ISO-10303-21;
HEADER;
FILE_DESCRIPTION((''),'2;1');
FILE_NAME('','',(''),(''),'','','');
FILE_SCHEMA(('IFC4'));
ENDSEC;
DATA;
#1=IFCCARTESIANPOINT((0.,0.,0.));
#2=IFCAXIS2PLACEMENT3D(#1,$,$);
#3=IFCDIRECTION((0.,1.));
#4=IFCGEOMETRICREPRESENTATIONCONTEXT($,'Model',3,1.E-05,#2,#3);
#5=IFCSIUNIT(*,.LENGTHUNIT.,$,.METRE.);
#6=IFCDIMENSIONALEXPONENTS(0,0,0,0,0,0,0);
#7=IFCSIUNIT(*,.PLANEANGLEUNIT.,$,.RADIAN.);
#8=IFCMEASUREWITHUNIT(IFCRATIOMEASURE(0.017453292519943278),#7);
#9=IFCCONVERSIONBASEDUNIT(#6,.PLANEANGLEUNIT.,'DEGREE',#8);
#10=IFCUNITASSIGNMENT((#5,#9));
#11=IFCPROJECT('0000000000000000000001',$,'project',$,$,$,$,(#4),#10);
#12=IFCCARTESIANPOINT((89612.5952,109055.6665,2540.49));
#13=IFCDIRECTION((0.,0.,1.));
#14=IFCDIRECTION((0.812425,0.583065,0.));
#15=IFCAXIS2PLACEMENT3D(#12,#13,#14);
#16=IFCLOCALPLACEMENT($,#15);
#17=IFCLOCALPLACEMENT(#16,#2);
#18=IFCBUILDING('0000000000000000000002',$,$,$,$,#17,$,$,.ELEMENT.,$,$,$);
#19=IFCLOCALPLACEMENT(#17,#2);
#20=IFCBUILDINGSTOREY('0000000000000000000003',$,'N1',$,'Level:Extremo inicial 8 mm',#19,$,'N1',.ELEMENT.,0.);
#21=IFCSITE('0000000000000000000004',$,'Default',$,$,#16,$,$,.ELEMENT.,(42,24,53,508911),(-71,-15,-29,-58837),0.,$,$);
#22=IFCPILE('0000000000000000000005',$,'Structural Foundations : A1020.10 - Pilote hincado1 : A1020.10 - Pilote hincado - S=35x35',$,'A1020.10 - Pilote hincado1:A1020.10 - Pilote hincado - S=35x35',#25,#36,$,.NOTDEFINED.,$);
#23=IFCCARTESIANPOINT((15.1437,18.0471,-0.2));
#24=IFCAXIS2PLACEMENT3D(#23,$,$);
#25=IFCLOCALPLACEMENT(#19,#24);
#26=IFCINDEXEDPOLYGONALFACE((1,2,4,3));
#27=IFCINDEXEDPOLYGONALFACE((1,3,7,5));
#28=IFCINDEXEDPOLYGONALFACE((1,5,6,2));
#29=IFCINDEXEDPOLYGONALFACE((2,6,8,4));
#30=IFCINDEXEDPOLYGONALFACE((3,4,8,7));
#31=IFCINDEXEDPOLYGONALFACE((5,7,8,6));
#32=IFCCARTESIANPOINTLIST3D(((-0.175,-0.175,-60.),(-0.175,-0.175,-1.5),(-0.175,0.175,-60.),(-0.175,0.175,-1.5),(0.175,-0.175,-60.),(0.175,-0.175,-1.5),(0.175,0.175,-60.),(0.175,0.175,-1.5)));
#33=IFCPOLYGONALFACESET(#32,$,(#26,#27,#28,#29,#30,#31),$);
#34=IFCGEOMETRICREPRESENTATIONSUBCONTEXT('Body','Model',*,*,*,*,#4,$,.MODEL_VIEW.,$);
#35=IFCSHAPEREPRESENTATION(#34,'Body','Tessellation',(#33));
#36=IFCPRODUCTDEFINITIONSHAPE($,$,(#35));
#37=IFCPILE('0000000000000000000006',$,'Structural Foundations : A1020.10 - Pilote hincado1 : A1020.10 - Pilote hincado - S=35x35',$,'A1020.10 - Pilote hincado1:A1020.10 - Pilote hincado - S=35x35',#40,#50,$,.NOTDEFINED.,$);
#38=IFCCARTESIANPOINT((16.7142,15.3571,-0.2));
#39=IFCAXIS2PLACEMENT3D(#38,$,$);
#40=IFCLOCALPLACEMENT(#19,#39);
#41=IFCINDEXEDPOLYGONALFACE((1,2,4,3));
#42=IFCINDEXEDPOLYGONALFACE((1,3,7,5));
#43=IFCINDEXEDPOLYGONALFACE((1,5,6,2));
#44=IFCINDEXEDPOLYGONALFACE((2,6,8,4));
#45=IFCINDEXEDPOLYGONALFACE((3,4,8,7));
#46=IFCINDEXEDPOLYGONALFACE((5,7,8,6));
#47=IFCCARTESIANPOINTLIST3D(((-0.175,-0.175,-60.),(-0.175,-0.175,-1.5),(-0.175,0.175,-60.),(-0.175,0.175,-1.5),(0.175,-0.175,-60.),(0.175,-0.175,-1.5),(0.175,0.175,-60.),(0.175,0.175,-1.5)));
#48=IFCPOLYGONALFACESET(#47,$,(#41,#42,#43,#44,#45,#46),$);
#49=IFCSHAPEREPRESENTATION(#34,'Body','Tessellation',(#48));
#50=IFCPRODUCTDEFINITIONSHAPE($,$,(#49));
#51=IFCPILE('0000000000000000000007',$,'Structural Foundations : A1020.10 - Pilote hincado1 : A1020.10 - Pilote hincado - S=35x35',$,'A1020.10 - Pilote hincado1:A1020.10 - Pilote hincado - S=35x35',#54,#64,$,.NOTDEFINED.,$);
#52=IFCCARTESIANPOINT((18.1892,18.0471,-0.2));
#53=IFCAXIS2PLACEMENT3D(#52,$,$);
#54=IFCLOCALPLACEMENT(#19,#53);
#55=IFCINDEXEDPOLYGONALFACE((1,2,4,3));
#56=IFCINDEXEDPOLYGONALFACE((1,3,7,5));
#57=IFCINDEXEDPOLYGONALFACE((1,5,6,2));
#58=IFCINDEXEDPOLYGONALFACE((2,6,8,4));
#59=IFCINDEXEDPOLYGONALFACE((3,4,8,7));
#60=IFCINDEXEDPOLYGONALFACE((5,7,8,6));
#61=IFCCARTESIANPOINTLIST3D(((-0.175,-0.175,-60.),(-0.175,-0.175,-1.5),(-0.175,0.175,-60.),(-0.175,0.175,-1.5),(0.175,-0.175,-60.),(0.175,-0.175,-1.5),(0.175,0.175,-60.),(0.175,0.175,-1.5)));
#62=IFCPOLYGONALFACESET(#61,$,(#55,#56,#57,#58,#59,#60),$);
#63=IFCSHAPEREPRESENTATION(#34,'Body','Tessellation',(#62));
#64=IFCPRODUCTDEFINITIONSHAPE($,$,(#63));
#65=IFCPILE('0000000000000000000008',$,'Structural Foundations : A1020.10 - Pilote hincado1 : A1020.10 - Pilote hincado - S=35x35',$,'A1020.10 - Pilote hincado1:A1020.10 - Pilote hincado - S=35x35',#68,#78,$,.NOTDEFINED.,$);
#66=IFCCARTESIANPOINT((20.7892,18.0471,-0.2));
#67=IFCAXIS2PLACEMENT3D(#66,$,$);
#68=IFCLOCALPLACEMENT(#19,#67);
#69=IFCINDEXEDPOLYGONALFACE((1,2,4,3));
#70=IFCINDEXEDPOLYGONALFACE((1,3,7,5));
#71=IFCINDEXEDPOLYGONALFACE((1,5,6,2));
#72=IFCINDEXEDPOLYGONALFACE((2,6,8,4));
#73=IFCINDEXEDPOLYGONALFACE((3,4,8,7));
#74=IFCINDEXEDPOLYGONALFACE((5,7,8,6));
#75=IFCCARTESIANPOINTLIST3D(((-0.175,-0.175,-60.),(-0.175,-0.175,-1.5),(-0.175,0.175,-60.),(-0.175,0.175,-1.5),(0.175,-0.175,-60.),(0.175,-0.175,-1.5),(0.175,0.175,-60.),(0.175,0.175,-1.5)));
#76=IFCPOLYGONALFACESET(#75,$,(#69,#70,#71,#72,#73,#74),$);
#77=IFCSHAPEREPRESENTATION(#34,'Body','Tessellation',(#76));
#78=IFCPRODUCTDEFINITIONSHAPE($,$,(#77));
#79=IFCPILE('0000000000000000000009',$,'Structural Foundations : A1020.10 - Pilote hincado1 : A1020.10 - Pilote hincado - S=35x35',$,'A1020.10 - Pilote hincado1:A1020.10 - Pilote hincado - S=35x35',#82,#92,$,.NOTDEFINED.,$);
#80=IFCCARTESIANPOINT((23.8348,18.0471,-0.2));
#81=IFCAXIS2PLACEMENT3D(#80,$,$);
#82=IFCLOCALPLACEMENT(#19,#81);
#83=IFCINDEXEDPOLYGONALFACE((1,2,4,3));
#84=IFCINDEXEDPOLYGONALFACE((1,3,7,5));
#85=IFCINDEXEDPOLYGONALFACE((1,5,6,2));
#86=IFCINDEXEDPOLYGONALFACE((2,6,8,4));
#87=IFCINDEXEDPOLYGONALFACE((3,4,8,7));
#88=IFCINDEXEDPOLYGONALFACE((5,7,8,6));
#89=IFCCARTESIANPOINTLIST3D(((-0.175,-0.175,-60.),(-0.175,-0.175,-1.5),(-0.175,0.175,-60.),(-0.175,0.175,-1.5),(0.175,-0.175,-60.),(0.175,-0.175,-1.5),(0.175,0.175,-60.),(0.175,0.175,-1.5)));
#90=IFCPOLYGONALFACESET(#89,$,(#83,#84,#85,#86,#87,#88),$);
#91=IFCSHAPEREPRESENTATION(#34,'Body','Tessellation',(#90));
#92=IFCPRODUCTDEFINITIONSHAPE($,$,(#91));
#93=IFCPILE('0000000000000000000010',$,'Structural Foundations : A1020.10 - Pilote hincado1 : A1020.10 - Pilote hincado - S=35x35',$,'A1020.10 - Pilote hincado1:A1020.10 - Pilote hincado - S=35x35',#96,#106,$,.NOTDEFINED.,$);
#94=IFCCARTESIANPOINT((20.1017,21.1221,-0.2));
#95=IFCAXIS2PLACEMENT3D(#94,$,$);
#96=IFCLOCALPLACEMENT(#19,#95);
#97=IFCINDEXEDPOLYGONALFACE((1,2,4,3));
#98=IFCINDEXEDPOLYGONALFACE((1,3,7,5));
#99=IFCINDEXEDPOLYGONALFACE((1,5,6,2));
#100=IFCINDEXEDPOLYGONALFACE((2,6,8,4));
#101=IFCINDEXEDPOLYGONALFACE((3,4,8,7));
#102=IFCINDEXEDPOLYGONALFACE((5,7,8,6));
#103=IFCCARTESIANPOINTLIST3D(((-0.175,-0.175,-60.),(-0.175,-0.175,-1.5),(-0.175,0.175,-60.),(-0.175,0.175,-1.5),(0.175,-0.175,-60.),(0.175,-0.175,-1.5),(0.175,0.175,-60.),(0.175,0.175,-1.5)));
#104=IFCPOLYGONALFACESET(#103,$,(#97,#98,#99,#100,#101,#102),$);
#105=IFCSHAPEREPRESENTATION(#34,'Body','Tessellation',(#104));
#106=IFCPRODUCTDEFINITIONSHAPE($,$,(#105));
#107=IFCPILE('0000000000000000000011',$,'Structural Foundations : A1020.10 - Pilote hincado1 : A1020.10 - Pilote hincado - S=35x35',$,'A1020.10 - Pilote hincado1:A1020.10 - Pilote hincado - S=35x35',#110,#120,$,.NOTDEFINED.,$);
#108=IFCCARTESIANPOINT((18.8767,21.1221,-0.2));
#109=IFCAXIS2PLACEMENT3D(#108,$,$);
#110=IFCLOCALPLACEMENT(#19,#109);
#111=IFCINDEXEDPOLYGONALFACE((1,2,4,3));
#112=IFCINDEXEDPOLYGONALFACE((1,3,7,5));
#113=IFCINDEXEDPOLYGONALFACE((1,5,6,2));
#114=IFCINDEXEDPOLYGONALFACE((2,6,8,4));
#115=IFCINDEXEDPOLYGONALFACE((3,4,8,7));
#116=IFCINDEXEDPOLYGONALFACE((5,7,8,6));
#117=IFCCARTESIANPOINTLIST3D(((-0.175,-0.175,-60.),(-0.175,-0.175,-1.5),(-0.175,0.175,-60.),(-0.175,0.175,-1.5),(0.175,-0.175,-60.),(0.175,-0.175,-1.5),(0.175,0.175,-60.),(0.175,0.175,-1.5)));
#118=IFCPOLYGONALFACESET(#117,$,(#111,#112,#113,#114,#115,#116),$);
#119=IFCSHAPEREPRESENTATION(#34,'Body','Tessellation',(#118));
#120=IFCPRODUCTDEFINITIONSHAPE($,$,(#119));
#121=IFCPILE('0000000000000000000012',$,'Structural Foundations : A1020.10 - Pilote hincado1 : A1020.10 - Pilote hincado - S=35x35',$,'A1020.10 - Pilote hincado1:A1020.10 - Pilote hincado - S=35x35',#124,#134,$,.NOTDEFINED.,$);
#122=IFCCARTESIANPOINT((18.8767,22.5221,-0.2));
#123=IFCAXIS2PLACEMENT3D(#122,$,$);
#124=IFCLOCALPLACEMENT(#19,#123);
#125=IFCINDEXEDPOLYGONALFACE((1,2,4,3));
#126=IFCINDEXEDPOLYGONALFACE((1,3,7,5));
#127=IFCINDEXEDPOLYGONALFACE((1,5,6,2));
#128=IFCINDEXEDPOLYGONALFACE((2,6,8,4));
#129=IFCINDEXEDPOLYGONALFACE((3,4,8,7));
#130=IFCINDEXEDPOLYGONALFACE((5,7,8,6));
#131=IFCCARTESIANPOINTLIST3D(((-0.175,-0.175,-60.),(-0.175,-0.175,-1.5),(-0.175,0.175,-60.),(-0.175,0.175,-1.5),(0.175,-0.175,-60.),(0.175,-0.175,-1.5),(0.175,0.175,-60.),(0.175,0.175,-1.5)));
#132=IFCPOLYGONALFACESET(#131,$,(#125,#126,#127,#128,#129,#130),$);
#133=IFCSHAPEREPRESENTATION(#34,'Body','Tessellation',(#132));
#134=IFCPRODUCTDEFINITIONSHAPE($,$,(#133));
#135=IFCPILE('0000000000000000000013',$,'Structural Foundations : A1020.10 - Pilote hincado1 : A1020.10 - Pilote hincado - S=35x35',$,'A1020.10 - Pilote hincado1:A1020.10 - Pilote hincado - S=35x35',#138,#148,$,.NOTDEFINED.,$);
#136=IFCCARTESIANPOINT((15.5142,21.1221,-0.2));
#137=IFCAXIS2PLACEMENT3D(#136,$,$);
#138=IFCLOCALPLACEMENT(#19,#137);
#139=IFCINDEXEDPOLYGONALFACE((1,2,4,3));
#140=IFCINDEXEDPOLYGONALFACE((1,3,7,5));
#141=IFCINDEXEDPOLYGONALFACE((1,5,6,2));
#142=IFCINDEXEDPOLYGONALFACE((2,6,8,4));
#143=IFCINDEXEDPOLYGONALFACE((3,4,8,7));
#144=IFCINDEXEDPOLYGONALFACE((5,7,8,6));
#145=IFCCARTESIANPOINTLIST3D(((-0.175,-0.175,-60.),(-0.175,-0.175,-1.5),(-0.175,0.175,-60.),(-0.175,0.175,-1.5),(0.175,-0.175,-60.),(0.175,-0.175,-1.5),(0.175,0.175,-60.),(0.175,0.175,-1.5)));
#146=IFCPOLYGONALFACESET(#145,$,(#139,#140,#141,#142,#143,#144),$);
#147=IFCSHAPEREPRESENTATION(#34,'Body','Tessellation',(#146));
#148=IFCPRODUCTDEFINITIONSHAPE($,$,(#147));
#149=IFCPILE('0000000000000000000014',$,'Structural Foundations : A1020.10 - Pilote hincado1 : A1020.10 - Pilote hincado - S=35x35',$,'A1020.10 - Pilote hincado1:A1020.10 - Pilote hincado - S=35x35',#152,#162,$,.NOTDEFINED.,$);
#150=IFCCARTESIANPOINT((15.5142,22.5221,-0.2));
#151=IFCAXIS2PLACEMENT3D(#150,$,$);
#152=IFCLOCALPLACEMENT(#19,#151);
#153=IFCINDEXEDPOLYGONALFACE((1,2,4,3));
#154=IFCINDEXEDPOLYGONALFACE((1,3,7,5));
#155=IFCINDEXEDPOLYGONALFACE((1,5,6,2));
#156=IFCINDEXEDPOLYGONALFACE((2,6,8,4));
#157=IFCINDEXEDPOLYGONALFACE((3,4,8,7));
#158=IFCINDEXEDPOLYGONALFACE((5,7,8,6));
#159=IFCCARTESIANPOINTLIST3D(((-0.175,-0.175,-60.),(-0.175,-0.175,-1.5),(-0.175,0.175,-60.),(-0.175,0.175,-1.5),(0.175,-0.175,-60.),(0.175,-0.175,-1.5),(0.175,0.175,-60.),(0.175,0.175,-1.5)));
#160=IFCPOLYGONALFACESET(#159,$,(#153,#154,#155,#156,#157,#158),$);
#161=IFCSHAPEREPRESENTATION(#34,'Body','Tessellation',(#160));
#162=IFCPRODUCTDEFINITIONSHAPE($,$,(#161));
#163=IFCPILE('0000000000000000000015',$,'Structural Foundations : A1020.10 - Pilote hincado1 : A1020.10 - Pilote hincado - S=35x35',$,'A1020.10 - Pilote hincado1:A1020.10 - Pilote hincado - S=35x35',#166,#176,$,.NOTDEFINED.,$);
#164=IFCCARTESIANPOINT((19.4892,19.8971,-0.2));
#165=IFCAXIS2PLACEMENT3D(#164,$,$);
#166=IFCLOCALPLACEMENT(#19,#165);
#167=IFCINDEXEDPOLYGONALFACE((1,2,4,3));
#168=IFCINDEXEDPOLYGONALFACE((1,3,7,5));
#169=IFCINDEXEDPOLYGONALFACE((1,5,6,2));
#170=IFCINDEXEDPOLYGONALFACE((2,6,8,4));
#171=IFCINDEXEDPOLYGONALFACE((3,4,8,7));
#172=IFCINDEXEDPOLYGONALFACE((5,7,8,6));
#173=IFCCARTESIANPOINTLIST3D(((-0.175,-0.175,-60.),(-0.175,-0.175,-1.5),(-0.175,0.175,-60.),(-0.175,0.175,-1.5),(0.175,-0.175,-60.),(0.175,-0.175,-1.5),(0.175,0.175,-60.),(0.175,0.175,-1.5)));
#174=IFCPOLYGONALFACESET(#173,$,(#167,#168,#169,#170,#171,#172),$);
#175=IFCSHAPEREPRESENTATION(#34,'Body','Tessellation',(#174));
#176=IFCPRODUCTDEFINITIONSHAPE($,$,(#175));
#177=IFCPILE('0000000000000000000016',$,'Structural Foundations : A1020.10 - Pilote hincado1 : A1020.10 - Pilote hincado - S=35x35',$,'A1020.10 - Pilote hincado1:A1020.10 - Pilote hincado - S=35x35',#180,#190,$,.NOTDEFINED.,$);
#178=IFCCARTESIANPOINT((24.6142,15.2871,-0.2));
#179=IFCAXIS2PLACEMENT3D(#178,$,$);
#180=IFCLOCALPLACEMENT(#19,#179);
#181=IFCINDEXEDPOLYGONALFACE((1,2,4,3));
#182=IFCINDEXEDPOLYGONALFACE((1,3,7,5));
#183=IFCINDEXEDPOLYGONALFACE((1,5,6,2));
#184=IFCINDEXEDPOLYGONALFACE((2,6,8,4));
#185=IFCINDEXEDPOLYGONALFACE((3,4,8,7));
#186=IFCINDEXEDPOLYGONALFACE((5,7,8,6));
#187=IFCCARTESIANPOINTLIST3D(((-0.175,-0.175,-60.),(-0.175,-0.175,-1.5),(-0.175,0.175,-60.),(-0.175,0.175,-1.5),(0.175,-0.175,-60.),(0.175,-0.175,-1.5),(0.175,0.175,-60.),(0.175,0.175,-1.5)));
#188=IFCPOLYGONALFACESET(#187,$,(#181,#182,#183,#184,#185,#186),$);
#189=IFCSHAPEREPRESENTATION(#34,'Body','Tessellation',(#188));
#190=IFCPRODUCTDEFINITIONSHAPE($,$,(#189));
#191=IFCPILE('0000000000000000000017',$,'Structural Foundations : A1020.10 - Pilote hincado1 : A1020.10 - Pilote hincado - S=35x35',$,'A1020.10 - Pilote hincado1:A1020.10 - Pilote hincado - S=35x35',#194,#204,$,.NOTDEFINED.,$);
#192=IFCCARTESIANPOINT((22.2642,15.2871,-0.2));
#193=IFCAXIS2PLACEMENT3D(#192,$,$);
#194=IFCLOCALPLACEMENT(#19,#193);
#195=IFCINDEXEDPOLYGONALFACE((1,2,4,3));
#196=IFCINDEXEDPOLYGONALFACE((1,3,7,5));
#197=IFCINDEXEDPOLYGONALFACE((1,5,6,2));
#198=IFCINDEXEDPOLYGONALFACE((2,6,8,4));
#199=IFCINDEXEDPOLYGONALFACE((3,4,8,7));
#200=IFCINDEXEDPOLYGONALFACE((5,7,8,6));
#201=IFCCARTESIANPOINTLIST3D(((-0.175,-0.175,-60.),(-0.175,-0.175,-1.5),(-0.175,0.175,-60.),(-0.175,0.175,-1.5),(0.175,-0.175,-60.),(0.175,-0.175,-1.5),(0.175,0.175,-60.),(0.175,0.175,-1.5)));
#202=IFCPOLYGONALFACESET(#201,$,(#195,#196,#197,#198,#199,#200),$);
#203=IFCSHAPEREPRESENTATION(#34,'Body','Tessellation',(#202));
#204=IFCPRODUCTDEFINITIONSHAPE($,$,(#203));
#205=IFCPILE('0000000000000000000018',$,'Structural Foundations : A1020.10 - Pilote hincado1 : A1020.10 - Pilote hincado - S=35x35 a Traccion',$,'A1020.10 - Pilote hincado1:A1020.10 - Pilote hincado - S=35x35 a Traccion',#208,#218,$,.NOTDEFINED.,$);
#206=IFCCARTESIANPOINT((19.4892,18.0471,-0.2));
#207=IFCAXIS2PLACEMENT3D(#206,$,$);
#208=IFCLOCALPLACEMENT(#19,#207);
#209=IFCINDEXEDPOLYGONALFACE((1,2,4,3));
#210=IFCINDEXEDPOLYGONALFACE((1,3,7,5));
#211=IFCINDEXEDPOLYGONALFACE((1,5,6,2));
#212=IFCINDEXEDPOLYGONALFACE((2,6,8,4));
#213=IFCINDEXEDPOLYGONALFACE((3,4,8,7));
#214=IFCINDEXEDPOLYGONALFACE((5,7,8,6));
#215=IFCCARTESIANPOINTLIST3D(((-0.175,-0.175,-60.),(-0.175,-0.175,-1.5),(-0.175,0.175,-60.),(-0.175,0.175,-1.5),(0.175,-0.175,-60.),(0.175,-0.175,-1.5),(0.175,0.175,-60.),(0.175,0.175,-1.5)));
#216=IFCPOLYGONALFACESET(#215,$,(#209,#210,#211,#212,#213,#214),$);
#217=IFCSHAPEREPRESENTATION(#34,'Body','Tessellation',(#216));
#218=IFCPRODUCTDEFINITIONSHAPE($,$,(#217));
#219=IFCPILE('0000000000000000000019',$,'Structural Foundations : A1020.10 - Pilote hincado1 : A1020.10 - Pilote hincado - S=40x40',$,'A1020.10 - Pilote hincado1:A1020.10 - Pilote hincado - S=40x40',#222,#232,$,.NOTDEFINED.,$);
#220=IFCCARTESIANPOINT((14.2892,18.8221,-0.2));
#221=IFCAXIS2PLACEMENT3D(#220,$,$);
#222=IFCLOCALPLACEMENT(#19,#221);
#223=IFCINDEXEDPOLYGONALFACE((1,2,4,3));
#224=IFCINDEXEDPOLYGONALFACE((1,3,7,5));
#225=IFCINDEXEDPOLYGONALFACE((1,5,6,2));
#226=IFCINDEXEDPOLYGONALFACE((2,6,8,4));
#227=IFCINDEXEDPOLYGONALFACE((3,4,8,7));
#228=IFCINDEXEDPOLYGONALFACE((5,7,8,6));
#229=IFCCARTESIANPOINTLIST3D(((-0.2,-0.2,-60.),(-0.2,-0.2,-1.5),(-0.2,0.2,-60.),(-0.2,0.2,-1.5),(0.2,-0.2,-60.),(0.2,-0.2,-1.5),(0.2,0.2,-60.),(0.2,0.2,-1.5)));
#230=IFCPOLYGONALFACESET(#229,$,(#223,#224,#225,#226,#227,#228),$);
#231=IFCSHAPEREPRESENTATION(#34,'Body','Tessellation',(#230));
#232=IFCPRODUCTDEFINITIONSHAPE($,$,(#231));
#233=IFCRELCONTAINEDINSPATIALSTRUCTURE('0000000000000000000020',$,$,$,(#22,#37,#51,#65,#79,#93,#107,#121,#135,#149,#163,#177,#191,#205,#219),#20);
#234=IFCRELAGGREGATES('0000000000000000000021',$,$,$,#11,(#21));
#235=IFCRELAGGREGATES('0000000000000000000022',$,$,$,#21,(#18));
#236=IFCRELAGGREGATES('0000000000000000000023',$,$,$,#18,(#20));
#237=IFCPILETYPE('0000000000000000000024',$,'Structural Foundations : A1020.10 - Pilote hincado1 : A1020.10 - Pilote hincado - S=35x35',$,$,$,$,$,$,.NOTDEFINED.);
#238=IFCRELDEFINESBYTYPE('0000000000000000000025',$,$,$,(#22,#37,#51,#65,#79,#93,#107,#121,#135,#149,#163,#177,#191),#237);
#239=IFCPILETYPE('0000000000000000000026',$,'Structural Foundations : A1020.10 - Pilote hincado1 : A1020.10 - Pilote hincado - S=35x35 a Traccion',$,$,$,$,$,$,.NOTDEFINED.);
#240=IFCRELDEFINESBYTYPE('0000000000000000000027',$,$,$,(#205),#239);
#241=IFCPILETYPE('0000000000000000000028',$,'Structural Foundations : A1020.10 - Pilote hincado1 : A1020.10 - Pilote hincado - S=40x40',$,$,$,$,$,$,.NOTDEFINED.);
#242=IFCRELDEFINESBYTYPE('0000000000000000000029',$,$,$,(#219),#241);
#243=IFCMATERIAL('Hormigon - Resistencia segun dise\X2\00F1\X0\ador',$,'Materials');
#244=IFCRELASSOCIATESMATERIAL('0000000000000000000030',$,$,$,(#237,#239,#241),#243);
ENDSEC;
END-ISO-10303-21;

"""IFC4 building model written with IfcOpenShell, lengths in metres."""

from ifc_helpers import new_model, entity, si_unit, converted_unit, direction, frame, origin, origin_2d_with_axis, place, context, subcontext, project, spatial, polyline, segment, composite_curve, rectangle, outline, extrude, source, transform, mapped, material, material_profile, profile_set, type_object, type_shapes, element, save


model = new_model("IFC4")

# Units and contexts
model_context = context("Model", 3, precision=1e-05, world=origin(), true_north=direction((0.0, 1.0)))
body_context = subcontext(model_context, "Body", "Model", "MODEL_VIEW")
ifc_project = project(units=[si_unit("LENGTHUNIT", "METRE"), converted_unit("PLANEANGLEUNIT", "DEGREE", entity("IfcRatioMeasure", 0.017453292519943278), si_unit("PLANEANGLEUNIT", "RADIAN"), dimensions=[0, 0, 0, 0, 0, 0, 0])], contexts=[model_context])

# Site, building, storey
site_placement = place(None, frame((89612.5952, 109055.6665, 2540.49), z_axis=(0.0, 0.0, 1.0), x_axis=(0.812425, 0.583065, 0.0)))
site = spatial("IfcSite", under=ifc_project, at=site_placement, Name="Default", CompositionType="ELEMENT", RefLatitude=(42, 24, 53, 508911), RefLongitude=(-71, -15, -29, -58837), RefElevation=0.0)
building_placement = place(site_placement, origin())
building = spatial("IfcBuilding", under=site, at=building_placement, CompositionType="ELEMENT")
storey_placement = place(building_placement, origin())
storey = spatial("IfcBuildingStorey", under=building, at=storey_placement, Name="N1", ObjectType="Level:Extremo inicial 8 mm", LongName="N1", CompositionType="ELEMENT", Elevation=0.0)

# Piles
ifc_material_1 = material(Name="Hormigon - Resistencia segun diseñador", Category="Materials")
ifc_material_profile_1 = material_profile(ifc_material_1, outline(composite_curve([segment(polyline([(0.175, 0.175, -60.0), (0.175, -0.175, -60.0)]), True, "CONTINUOUS"), segment(polyline([(0.175, -0.175, -60.0), (-0.175, -0.175, -60.0)]), True, "CONTINUOUS"), segment(polyline([(-0.175, -0.175, -60.0), (-0.175, 0.175, -60.0)]), True, "CONTINUOUS"), segment(polyline([(-0.175, 0.175, -60.0), (0.175, 0.175, -60.0)]), True, "CONTINUOUS")], self_intersect=False), kind="CURVE"), Name="A1020.10 - Pilote hincado - S=35x35")
ifc_profile_set_1 = profile_set([ifc_material_profile_1], Name="A1020.10 - Pilote hincado - S=35x35")
pile_type_1 = type_object("IfcPileType", Name="Structural Foundations : A1020.10 - Pilote hincado1 : A1020.10 - Pilote hincado - S=35x35", PredefinedType="NOTDEFINED", material=ifc_profile_set_1)
shared_shape_1 = source(origin(), body_context, "Body", "SweptSolid", [
    extrude(rectangle(XDim=0.35, YDim=0.35, at=origin_2d_with_axis()), frame((0.0, 0.0, -60.0), z_axis=(0.0, 0.0, 1.0), x_axis=(0.0, -1.0, 0.0)), (0.0, 0.0, 1.0), 58.5),
])
type_shapes(pile_type_1, [shared_shape_1])
for number, where, name in (
    (1, (15.1437, 18.0471, -0.2), "Structural Foundations : A1020.10 - Pilote hincado1 : A1020.10 - Pilote hincado - S=35x35"),
    (2, (16.7142, 15.3571, -0.2), "Structural Foundations : A1020.10 - Pilote hincado1 : A1020.10 - Pilote hincado - S=35x35"),
    (3, (18.1892, 18.0471, -0.2), "Structural Foundations : A1020.10 - Pilote hincado1 : A1020.10 - Pilote hincado - S=35x35"),
    (4, (20.7892, 18.0471, -0.2), "Structural Foundations : A1020.10 - Pilote hincado1 : A1020.10 - Pilote hincado - S=35x35"),
    (5, (23.8348, 18.0471, -0.2), "Structural Foundations : A1020.10 - Pilote hincado1 : A1020.10 - Pilote hincado - S=35x35"),
    (6, (20.1017, 21.1221, -0.2), "Structural Foundations : A1020.10 - Pilote hincado1 : A1020.10 - Pilote hincado - S=35x35"),
    (7, (18.8767, 21.1221, -0.2), "Structural Foundations : A1020.10 - Pilote hincado1 : A1020.10 - Pilote hincado - S=35x35"),
    (8, (18.8767, 22.5221, -0.2), "Structural Foundations : A1020.10 - Pilote hincado1 : A1020.10 - Pilote hincado - S=35x35"),
    (9, (15.5142, 21.1221, -0.2), "Structural Foundations : A1020.10 - Pilote hincado1 : A1020.10 - Pilote hincado - S=35x35"),
    (10, (15.5142, 22.5221, -0.2), "Structural Foundations : A1020.10 - Pilote hincado1 : A1020.10 - Pilote hincado - S=35x35"),
    (11, (19.4892, 19.8971, -0.2), "Structural Foundations : A1020.10 - Pilote hincado1 : A1020.10 - Pilote hincado - S=35x35"),
    (12, (24.6142, 15.2871, -0.2), "Structural Foundations : A1020.10 - Pilote hincado1 : A1020.10 - Pilote hincado - S=35x35"),
    (13, (22.2642, 15.2871, -0.2), "Structural Foundations : A1020.10 - Pilote hincado1 : A1020.10 - Pilote hincado - S=35x35"),
):
    element("IfcPile", number, at=place(storey_placement, frame(where)), inside=storey, type_object=pile_type_1, Name=name, ObjectType="A1020.10 - Pilote hincado1:A1020.10 - Pilote hincado - S=35x35", PredefinedType="NOTDEFINED", context=body_context, shape_type="MappedRepresentation", body=[
        mapped(shared_shape_1, transform((0.0, 0.0, 0.0), scale=1.0)),
    ])
ifc_material_profile_2 = material_profile(ifc_material_1, outline(composite_curve([segment(polyline([(0.175, 0.175, -60.0), (0.175, -0.175, -60.0)]), True, "CONTINUOUS"), segment(polyline([(0.175, -0.175, -60.0), (-0.175, -0.175, -60.0)]), True, "CONTINUOUS"), segment(polyline([(-0.175, -0.175, -60.0), (-0.175, 0.175, -60.0)]), True, "CONTINUOUS"), segment(polyline([(-0.175, 0.175, -60.0), (0.175, 0.175, -60.0)]), True, "CONTINUOUS")], self_intersect=False), kind="CURVE"), Name="A1020.10 - Pilote hincado - S=35x35 a Traccion")
ifc_profile_set_2 = profile_set([ifc_material_profile_2], Name="A1020.10 - Pilote hincado - S=35x35 a Traccion")
pile_type_2 = type_object("IfcPileType", Name="Structural Foundations : A1020.10 - Pilote hincado1 : A1020.10 - Pilote hincado - S=35x35 a Traccion", PredefinedType="NOTDEFINED", material=ifc_profile_set_2)
shared_shape_2 = source(origin(), body_context, "Body", "SweptSolid", [
    extrude(rectangle(XDim=0.35, YDim=0.35, at=origin_2d_with_axis()), frame((0.0, 0.0, -60.0), z_axis=(0.0, 0.0, 1.0), x_axis=(0.0, -1.0, 0.0)), (0.0, 0.0, 1.0), 58.5),
])
type_shapes(pile_type_2, [shared_shape_2])
pile_1_placement = place(storey_placement, frame((19.4892, 18.0471, -0.2)))
element("IfcPile", 14, at=pile_1_placement, inside=storey, type_object=pile_type_2, Name="Structural Foundations : A1020.10 - Pilote hincado1 : A1020.10 - Pilote hincado - S=35x35 a Traccion", ObjectType="A1020.10 - Pilote hincado1:A1020.10 - Pilote hincado - S=35x35 a Traccion", PredefinedType="NOTDEFINED", context=body_context, shape_type="MappedRepresentation", body=[
    mapped(shared_shape_2, transform((0.0, 0.0, 0.0), scale=1.0)),
])
ifc_material_profile_3 = material_profile(ifc_material_1, outline(composite_curve([segment(polyline([(0.2, 0.2, -60.0), (0.2, -0.2, -60.0)]), True, "CONTINUOUS"), segment(polyline([(0.2, -0.2, -60.0), (-0.2, -0.2, -60.0)]), True, "CONTINUOUS"), segment(polyline([(-0.2, -0.2, -60.0), (-0.2, 0.2, -60.0)]), True, "CONTINUOUS"), segment(polyline([(-0.2, 0.2, -60.0), (0.2, 0.2, -60.0)]), True, "CONTINUOUS")], self_intersect=False), kind="CURVE"), Name="A1020.10 - Pilote hincado - S=40x40")
ifc_profile_set_3 = profile_set([ifc_material_profile_3], Name="A1020.10 - Pilote hincado - S=40x40")
pile_type_3 = type_object("IfcPileType", Name="Structural Foundations : A1020.10 - Pilote hincado1 : A1020.10 - Pilote hincado - S=40x40", PredefinedType="NOTDEFINED", material=ifc_profile_set_3)
shared_shape_3 = source(origin(), body_context, "Body", "SweptSolid", [
    extrude(rectangle(XDim=0.4, YDim=0.4, at=origin_2d_with_axis()), frame((0.0, 0.0, -60.0), z_axis=(0.0, 0.0, 1.0), x_axis=(0.0, -1.0, 0.0)), (0.0, 0.0, 1.0), 58.5),
])
type_shapes(pile_type_3, [shared_shape_3])
pile_2_placement = place(storey_placement, frame((14.2892, 18.8221, -0.2)))
element("IfcPile", 15, at=pile_2_placement, inside=storey, type_object=pile_type_3, Name="Structural Foundations : A1020.10 - Pilote hincado1 : A1020.10 - Pilote hincado - S=40x40", ObjectType="A1020.10 - Pilote hincado1:A1020.10 - Pilote hincado - S=40x40", PredefinedType="NOTDEFINED", context=body_context, shape_type="MappedRepresentation", body=[
    mapped(shared_shape_3, transform((0.0, 0.0, 0.0), scale=1.0)),
])

save(model, "model.ifc")
